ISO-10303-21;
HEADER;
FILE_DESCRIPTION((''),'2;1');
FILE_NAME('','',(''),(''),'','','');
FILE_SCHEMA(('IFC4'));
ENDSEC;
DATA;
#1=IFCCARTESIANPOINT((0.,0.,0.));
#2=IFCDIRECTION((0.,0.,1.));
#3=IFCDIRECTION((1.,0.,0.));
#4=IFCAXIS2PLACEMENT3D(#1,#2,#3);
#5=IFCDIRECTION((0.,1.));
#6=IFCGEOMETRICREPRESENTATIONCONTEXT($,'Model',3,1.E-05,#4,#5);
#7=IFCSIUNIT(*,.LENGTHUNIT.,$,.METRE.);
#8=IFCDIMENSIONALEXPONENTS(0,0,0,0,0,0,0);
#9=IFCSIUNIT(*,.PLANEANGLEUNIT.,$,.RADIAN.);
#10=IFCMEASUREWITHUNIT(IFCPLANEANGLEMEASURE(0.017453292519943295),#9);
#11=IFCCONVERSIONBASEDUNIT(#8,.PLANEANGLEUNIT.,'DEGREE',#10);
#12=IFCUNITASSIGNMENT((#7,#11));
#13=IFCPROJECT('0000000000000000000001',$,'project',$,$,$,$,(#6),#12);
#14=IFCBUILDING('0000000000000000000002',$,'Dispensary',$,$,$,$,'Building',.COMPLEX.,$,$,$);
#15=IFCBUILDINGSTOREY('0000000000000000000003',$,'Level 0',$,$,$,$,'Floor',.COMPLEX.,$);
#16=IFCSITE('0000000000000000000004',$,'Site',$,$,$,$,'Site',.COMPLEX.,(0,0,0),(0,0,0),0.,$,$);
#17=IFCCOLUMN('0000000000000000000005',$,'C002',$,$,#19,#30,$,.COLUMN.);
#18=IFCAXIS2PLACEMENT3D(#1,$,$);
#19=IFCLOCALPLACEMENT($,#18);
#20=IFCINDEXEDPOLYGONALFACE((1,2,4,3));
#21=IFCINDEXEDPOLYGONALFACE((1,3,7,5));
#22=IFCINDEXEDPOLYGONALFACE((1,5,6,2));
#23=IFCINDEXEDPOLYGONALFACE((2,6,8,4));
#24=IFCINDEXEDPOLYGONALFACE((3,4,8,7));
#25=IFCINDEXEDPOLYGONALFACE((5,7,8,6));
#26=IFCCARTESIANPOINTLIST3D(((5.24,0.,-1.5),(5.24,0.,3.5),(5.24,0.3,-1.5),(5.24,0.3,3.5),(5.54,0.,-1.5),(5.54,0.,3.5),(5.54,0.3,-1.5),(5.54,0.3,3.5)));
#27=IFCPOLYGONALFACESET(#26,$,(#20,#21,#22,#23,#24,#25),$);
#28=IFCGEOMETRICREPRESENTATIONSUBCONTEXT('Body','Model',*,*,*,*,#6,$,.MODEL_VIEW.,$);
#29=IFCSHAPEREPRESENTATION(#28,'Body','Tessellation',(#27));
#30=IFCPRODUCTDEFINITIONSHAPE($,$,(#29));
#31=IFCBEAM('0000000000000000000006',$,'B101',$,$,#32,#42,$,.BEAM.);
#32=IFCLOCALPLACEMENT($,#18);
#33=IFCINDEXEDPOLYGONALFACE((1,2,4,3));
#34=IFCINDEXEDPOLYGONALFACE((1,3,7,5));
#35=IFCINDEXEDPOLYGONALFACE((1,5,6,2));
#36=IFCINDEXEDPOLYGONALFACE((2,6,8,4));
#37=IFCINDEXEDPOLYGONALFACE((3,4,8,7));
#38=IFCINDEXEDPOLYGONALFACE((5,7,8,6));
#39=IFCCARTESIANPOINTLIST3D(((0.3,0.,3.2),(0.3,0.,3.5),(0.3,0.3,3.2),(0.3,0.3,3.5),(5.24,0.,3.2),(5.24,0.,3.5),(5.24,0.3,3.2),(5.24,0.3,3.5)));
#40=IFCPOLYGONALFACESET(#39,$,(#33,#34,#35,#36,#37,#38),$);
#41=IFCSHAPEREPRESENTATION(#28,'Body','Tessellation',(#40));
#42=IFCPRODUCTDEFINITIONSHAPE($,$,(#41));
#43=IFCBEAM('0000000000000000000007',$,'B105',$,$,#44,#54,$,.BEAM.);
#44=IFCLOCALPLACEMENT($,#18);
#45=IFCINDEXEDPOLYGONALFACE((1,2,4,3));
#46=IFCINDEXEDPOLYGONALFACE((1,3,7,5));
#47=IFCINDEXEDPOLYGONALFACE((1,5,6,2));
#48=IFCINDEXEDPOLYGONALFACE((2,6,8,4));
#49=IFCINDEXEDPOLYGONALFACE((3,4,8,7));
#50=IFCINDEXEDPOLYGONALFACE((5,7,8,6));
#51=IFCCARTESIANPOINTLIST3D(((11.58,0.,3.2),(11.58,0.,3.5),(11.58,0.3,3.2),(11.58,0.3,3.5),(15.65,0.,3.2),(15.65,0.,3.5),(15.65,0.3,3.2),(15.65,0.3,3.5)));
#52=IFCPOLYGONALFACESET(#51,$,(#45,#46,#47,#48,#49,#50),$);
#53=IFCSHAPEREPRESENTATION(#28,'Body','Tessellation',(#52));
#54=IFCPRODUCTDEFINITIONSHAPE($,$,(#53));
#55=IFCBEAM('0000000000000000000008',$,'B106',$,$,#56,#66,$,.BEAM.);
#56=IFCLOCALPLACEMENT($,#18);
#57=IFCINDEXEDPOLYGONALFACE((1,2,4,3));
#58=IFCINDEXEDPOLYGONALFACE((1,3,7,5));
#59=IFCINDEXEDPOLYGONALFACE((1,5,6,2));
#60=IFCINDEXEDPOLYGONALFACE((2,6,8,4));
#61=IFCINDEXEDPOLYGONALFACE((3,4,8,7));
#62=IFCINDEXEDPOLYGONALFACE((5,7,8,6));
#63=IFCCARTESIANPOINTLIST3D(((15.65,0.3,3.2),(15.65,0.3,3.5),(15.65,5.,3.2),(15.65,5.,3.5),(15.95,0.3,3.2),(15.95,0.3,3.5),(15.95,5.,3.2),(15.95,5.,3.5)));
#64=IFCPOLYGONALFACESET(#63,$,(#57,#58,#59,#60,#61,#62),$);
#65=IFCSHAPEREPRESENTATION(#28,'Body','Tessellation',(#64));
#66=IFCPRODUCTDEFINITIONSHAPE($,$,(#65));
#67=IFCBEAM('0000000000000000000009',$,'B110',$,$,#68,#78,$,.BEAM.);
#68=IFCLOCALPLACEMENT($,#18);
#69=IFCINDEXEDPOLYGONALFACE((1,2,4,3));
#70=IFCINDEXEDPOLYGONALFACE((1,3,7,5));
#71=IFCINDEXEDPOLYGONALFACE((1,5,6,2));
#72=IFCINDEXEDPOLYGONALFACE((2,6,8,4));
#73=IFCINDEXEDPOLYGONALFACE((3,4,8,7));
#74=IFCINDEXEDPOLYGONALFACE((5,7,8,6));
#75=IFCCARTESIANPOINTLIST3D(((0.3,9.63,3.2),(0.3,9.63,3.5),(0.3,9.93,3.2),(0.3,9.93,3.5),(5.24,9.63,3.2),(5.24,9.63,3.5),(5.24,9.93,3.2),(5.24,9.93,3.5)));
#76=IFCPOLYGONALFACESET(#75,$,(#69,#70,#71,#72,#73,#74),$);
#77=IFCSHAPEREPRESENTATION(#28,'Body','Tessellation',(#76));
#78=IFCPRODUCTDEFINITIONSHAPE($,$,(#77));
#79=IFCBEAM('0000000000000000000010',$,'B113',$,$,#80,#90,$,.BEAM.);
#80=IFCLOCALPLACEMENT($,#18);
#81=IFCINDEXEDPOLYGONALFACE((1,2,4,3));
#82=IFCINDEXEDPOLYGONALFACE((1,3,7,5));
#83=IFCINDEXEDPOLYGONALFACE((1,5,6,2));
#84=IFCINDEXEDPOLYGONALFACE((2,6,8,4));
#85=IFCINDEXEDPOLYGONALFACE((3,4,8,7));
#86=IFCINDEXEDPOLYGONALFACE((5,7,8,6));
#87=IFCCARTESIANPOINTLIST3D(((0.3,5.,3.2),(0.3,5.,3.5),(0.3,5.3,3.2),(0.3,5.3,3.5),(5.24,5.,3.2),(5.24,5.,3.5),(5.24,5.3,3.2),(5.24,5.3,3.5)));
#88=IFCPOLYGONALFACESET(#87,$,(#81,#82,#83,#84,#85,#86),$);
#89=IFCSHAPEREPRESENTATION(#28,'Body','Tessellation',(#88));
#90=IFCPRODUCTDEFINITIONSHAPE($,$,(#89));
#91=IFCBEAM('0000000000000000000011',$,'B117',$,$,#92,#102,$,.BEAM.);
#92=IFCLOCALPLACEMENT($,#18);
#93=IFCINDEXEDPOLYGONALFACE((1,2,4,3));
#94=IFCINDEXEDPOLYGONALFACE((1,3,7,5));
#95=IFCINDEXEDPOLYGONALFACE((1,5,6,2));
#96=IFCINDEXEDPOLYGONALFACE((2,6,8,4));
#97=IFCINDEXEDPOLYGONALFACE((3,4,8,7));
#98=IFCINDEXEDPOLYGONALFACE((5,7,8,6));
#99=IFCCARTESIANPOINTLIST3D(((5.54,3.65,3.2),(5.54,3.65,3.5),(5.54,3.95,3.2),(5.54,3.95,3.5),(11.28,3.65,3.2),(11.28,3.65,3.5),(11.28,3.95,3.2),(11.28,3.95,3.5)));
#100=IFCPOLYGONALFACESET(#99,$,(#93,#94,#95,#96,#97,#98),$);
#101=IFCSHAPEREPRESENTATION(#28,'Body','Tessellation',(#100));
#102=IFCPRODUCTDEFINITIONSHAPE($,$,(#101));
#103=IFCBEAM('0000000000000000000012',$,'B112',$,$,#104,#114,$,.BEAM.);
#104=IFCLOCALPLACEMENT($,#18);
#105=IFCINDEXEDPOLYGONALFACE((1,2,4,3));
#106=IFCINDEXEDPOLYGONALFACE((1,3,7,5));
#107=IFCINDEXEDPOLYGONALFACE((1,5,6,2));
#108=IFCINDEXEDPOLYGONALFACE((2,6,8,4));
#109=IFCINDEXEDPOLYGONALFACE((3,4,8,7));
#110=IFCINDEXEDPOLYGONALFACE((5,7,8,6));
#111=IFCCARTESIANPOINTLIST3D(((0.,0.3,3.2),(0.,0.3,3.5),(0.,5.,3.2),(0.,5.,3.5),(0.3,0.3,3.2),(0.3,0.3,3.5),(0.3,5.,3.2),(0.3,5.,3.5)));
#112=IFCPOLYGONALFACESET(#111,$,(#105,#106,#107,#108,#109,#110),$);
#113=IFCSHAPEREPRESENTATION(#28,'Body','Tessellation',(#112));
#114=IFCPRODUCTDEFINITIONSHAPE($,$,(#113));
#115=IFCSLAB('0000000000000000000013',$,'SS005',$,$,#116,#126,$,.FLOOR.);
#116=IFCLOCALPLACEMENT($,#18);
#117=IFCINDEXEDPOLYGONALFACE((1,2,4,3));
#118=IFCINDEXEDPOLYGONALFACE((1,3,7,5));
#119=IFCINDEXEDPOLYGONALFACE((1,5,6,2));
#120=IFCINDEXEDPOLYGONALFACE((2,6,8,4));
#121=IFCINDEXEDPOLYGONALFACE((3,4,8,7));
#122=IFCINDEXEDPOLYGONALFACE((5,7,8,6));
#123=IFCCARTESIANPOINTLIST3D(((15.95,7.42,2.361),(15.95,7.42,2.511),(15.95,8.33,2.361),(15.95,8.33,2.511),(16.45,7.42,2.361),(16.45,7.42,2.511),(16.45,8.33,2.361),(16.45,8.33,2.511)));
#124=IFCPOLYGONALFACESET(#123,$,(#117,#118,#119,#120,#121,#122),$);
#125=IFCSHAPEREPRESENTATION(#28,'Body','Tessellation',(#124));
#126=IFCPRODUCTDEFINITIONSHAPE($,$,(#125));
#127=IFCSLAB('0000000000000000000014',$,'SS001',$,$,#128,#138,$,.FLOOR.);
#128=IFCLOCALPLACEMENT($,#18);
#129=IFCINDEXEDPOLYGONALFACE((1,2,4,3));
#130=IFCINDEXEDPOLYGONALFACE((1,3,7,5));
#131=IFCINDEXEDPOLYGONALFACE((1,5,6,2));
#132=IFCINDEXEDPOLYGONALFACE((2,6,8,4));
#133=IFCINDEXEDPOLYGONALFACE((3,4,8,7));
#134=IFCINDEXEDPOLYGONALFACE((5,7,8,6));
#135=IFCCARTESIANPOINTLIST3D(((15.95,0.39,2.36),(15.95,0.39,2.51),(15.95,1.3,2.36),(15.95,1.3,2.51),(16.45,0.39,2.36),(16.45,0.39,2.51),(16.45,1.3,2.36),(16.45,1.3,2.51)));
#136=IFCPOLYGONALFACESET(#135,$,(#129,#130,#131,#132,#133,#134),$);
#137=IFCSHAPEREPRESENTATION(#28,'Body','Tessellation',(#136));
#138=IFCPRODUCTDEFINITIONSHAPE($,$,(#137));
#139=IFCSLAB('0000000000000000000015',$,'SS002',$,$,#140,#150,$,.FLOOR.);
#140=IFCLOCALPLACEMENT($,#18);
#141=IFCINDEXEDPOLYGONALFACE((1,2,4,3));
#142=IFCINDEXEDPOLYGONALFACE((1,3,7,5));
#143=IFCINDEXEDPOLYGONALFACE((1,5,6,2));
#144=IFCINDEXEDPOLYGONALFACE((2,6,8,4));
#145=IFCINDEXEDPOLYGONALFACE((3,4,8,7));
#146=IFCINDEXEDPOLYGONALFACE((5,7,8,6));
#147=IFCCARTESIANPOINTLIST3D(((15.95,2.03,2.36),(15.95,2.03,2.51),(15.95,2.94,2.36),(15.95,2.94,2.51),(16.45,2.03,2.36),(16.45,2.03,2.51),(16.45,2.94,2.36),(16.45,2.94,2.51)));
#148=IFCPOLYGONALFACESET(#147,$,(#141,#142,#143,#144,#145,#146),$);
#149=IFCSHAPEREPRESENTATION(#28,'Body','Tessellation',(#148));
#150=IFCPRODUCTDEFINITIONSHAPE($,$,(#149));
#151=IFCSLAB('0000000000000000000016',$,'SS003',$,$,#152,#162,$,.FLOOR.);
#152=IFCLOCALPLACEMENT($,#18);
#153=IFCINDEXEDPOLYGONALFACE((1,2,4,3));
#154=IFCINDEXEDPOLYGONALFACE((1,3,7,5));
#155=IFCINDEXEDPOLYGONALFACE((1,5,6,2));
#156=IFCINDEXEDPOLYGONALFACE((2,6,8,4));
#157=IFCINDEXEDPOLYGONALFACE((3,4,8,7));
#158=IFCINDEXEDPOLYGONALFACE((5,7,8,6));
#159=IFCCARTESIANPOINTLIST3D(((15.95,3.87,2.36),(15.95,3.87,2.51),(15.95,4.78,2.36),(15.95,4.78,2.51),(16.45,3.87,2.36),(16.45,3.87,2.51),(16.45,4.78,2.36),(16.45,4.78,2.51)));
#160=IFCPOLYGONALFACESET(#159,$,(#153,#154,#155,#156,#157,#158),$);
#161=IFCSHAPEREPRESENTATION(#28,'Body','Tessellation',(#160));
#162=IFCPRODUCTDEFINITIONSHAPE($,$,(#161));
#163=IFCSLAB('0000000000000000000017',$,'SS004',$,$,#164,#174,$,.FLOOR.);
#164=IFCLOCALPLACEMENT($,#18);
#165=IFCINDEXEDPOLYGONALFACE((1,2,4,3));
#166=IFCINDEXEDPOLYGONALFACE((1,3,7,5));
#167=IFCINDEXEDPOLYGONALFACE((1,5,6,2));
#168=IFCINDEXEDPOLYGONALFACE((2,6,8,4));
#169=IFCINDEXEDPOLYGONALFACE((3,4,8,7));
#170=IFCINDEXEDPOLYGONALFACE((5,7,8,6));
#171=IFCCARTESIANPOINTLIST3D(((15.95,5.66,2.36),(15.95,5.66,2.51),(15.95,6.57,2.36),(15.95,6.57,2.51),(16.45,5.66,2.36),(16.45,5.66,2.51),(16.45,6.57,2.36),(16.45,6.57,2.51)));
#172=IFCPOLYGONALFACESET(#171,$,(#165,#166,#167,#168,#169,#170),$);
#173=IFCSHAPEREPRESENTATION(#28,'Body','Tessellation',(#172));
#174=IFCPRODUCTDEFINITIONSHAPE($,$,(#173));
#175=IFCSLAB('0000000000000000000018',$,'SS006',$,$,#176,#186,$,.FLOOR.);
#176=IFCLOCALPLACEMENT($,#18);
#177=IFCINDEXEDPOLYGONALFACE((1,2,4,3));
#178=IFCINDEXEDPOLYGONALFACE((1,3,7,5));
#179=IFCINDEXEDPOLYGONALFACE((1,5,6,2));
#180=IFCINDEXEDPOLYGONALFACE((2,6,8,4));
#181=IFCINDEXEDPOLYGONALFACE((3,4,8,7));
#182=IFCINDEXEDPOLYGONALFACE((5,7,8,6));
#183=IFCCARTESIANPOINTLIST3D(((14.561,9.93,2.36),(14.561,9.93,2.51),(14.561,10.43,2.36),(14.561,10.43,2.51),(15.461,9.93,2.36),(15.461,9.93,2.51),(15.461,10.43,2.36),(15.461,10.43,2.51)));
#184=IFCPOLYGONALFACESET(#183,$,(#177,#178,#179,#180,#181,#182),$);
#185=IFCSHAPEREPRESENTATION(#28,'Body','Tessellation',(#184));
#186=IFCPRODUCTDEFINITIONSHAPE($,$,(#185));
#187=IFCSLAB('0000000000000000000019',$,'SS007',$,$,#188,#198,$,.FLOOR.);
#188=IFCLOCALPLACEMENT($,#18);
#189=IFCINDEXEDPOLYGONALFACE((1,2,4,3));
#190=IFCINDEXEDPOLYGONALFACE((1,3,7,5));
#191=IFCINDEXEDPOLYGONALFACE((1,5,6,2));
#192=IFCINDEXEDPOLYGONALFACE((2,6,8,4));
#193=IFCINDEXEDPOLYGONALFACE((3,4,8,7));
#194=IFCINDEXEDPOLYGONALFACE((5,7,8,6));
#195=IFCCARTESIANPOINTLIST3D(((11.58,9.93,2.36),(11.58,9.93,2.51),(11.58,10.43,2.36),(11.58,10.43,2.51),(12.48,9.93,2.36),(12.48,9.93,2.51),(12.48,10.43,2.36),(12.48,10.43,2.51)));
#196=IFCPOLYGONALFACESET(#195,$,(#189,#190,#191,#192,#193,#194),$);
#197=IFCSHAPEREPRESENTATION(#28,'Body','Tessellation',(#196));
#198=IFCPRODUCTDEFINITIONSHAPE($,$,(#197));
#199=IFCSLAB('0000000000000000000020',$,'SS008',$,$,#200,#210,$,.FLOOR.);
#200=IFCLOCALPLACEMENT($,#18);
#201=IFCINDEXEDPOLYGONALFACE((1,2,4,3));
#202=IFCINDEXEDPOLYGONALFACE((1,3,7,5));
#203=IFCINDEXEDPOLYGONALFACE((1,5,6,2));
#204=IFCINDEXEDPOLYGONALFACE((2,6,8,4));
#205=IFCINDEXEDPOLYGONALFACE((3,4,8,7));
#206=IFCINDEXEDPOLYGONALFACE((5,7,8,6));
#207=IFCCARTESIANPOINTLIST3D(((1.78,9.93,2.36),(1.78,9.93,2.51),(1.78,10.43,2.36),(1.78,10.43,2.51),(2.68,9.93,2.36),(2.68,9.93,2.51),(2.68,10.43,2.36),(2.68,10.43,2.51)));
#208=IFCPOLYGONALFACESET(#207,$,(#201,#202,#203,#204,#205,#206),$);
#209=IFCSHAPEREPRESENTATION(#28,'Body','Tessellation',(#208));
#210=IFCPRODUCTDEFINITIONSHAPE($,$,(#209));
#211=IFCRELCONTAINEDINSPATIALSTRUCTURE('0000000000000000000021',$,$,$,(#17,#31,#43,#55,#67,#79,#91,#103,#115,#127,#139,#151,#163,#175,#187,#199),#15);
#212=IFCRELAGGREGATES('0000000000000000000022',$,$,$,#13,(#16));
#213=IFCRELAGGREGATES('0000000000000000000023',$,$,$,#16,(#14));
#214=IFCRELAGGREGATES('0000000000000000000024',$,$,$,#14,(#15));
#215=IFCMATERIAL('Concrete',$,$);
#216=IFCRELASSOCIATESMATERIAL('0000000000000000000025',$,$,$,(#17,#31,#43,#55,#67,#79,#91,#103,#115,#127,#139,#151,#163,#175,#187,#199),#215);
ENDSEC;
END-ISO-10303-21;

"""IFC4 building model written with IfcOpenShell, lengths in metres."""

from ifc_helpers import new_model, entity, si_unit, converted_unit, direction, frame, frame_2d, origin_with_axes, place, context, subcontext, project, spatial, rectangle, extrude, material, element, save


model = new_model("IFC4")

# Units and contexts
model_context = context("Model", 3, precision=1e-05, world=origin_with_axes(), true_north=direction((0.0, 1.0)))
body_context = subcontext(model_context, "Body", "Model", "MODEL_VIEW")
ifc_project = project(units=[si_unit("LENGTHUNIT", "METRE"), converted_unit("PLANEANGLEUNIT", "DEGREE", entity("IfcPlaneAngleMeasure", 0.017453292519943295), si_unit("PLANEANGLEUNIT", "RADIAN"), dimensions=[0, 0, 0, 0, 0, 0, 0])], contexts=[model_context])

# Site, building, storey
site = spatial("IfcSite", under=ifc_project, Name="Site", LongName="Site", CompositionType="COMPLEX", RefLatitude=(0, 0, 0), RefLongitude=(0, 0, 0), RefElevation=0.0)
building = spatial("IfcBuilding", under=site, Name="Dispensary", LongName="Building", CompositionType="COMPLEX")
storey = spatial("IfcBuildingStorey", under=building, Name="Level 0", LongName="Floor", CompositionType="COMPLEX")

# Column
ifc_material_1 = material(Name="Concrete")
placement = place(None, origin_with_axes())
element("IfcColumn", 1, at=placement, inside=storey, material=ifc_material_1, Name="C002", PredefinedType="COLUMN", context=body_context, shape_type="SweptSolid", body=[
    extrude(rectangle(XDim=0.3, YDim=0.3, at=frame_2d((0.0, 0.0), x_axis=(1.0, 0.0))), frame((5.39, 0.15, -1.5), z_axis=(0.0, 0.0, 1.0), x_axis=(1.0, 0.0, 0.0)), (0.0, 0.0, 1.0), 5.0),
])

# Beams
element("IfcBeam", 2, at=placement, inside=storey, material=ifc_material_1, Name="B101", PredefinedType="BEAM", context=body_context, shape_type="SweptSolid", body=[
    extrude(rectangle(XDim=0.3, YDim=0.3, at=frame_2d((0.0, 0.0), x_axis=(0.0, 1.0))), frame((0.3, 0.15, 3.35), z_axis=(1.0, 0.0, 0.0), x_axis=(0.0, 0.0, -1.0)), (0.0, 0.0, 1.0), 4.94),
])
element("IfcBeam", 3, at=placement, inside=storey, material=ifc_material_1, Name="B105", PredefinedType="BEAM", context=body_context, shape_type="SweptSolid", body=[
    extrude(rectangle(XDim=0.3, YDim=0.3, at=frame_2d((0.0, 0.0), x_axis=(0.0, 1.0))), frame((11.58, 0.15, 3.35), z_axis=(1.0, 0.0, 0.0), x_axis=(0.0, 0.0, -1.0)), (0.0, 0.0, 1.0), 4.07),
])
element("IfcBeam", 4, at=placement, inside=storey, material=ifc_material_1, Name="B106", PredefinedType="BEAM", context=body_context, shape_type="SweptSolid", body=[
    extrude(rectangle(XDim=0.3, YDim=0.3, at=frame_2d((0.0, 0.0), x_axis=(0.0, 1.0))), frame((15.8, 0.3, 3.35), z_axis=(0.0, 1.0, 0.0), x_axis=(0.0, 0.0, -1.0)), (0.0, 0.0, 1.0), 4.7),
])
element("IfcBeam", 5, at=placement, inside=storey, material=ifc_material_1, Name="B110", PredefinedType="BEAM", context=body_context, shape_type="SweptSolid", body=[
    extrude(rectangle(XDim=0.3, YDim=0.3, at=frame_2d((0.0, 0.0), x_axis=(0.0, 1.0))), frame((5.24, 9.78, 3.35), z_axis=(-1.0, 0.0, 0.0), x_axis=(0.0, 0.0, -1.0)), (0.0, 0.0, 1.0), 4.94),
])
element("IfcBeam", 6, at=placement, inside=storey, material=ifc_material_1, Name="B113", PredefinedType="BEAM", context=body_context, shape_type="SweptSolid", body=[
    extrude(rectangle(XDim=0.3, YDim=0.3, at=frame_2d((0.0, 0.0), x_axis=(0.0, 1.0))), frame((5.24, 5.15, 3.35), z_axis=(-1.0, 0.0, 0.0), x_axis=(0.0, 0.0, -1.0)), (0.0, 0.0, 1.0), 4.94),
])
element("IfcBeam", 7, at=placement, inside=storey, material=ifc_material_1, Name="B117", PredefinedType="BEAM", context=body_context, shape_type="SweptSolid", body=[
    extrude(rectangle(XDim=0.3, YDim=0.3, at=frame_2d((0.0, 0.0), x_axis=(0.0, 1.0))), frame((5.54, 3.8, 3.35), z_axis=(1.0, 0.0, 0.0), x_axis=(0.0, 0.0, -1.0)), (0.0, 0.0, 1.0), 5.74),
])
element("IfcBeam", 8, at=placement, inside=storey, material=ifc_material_1, Name="B112", PredefinedType="BEAM", context=body_context, shape_type="SweptSolid", body=[
    extrude(rectangle(XDim=0.3, YDim=0.3, at=frame_2d((0.0, 0.0), x_axis=(0.0, 1.0))), frame((0.15, 0.3, 3.35), z_axis=(0.0, 1.0, 0.0), x_axis=(0.0, 0.0, -1.0)), (0.0, 0.0, 1.0), 4.7),
])

# Slabs
element("IfcSlab", 9, at=placement, inside=storey, material=ifc_material_1, Name="SS005", PredefinedType="FLOOR", context=body_context, shape_type="SweptSolid", body=[
    extrude(rectangle(XDim=0.91, YDim=0.15, at=frame_2d((0.0, 0.0), x_axis=(0.0, 1.0))), frame((16.45, 7.875, 2.436), z_axis=(-1.0, 0.0, 0.0), x_axis=(0.0, 0.0, 1.0)), (0.0, 0.0, 1.0), 0.5),
])
element("IfcSlab", 10, at=placement, inside=storey, material=ifc_material_1, Name="SS001", PredefinedType="FLOOR", context=body_context, shape_type="SweptSolid", body=[
    extrude(rectangle(XDim=0.91, YDim=0.15, at=frame_2d((0.0, 0.0), x_axis=(0.0, 1.0))), frame((16.45, 0.845, 2.435), z_axis=(-1.0, 0.0, 0.0), x_axis=(0.0, 0.0, 1.0)), (0.0, 0.0, 1.0), 0.5),
])
element("IfcSlab", 11, at=placement, inside=storey, material=ifc_material_1, Name="SS002", PredefinedType="FLOOR", context=body_context, shape_type="SweptSolid", body=[
    extrude(rectangle(XDim=0.91, YDim=0.15, at=frame_2d((0.0, 0.0), x_axis=(0.0, 1.0))), frame((16.45, 2.485, 2.435), z_axis=(-1.0, 0.0, 0.0), x_axis=(0.0, 0.0, 1.0)), (0.0, 0.0, 1.0), 0.5),
])
element("IfcSlab", 12, at=placement, inside=storey, material=ifc_material_1, Name="SS003", PredefinedType="FLOOR", context=body_context, shape_type="SweptSolid", body=[
    extrude(rectangle(XDim=0.91, YDim=0.15, at=frame_2d((0.0, 0.0), x_axis=(0.0, 1.0))), frame((16.45, 4.325, 2.435), z_axis=(-1.0, 0.0, 0.0), x_axis=(0.0, 0.0, 1.0)), (0.0, 0.0, 1.0), 0.5),
])
element("IfcSlab", 13, at=placement, inside=storey, material=ifc_material_1, Name="SS004", PredefinedType="FLOOR", context=body_context, shape_type="SweptSolid", body=[
    extrude(rectangle(XDim=0.91, YDim=0.15, at=frame_2d((0.0, 0.0), x_axis=(0.0, 1.0))), frame((16.45, 6.115, 2.435), z_axis=(-1.0, 0.0, 0.0), x_axis=(0.0, 0.0, 1.0)), (0.0, 0.0, 1.0), 0.5),
])
element("IfcSlab", 14, at=placement, inside=storey, material=ifc_material_1, Name="SS006", PredefinedType="FLOOR", context=body_context, shape_type="SweptSolid", body=[
    extrude(rectangle(XDim=0.9, YDim=0.15, at=frame_2d((0.0, 0.0), x_axis=(-1.0, 0.0))), frame((15.011, 10.43, 2.435), z_axis=(0.0, -1.0, 0.0), x_axis=(1.0, 0.0, 0.0)), (0.0, 0.0, 1.0), 0.5),
])
element("IfcSlab", 15, at=placement, inside=storey, material=ifc_material_1, Name="SS007", PredefinedType="FLOOR", context=body_context, shape_type="SweptSolid", body=[
    extrude(rectangle(XDim=0.9, YDim=0.15, at=frame_2d((0.0, 0.0), x_axis=(-1.0, 0.0))), frame((12.03, 10.43, 2.435), z_axis=(0.0, -1.0, 0.0), x_axis=(1.0, 0.0, 0.0)), (0.0, 0.0, 1.0), 0.5),
])
element("IfcSlab", 16, at=placement, inside=storey, material=ifc_material_1, Name="SS008", PredefinedType="FLOOR", context=body_context, shape_type="SweptSolid", body=[
    extrude(rectangle(XDim=0.9, YDim=0.15, at=frame_2d((0.0, 0.0), x_axis=(-1.0, 0.0))), frame((2.23, 10.43, 2.435), z_axis=(0.0, -1.0, 0.0), x_axis=(1.0, 0.0, 0.0)), (0.0, 0.0, 1.0), 0.5),
])

save(model, "model.ifc")
